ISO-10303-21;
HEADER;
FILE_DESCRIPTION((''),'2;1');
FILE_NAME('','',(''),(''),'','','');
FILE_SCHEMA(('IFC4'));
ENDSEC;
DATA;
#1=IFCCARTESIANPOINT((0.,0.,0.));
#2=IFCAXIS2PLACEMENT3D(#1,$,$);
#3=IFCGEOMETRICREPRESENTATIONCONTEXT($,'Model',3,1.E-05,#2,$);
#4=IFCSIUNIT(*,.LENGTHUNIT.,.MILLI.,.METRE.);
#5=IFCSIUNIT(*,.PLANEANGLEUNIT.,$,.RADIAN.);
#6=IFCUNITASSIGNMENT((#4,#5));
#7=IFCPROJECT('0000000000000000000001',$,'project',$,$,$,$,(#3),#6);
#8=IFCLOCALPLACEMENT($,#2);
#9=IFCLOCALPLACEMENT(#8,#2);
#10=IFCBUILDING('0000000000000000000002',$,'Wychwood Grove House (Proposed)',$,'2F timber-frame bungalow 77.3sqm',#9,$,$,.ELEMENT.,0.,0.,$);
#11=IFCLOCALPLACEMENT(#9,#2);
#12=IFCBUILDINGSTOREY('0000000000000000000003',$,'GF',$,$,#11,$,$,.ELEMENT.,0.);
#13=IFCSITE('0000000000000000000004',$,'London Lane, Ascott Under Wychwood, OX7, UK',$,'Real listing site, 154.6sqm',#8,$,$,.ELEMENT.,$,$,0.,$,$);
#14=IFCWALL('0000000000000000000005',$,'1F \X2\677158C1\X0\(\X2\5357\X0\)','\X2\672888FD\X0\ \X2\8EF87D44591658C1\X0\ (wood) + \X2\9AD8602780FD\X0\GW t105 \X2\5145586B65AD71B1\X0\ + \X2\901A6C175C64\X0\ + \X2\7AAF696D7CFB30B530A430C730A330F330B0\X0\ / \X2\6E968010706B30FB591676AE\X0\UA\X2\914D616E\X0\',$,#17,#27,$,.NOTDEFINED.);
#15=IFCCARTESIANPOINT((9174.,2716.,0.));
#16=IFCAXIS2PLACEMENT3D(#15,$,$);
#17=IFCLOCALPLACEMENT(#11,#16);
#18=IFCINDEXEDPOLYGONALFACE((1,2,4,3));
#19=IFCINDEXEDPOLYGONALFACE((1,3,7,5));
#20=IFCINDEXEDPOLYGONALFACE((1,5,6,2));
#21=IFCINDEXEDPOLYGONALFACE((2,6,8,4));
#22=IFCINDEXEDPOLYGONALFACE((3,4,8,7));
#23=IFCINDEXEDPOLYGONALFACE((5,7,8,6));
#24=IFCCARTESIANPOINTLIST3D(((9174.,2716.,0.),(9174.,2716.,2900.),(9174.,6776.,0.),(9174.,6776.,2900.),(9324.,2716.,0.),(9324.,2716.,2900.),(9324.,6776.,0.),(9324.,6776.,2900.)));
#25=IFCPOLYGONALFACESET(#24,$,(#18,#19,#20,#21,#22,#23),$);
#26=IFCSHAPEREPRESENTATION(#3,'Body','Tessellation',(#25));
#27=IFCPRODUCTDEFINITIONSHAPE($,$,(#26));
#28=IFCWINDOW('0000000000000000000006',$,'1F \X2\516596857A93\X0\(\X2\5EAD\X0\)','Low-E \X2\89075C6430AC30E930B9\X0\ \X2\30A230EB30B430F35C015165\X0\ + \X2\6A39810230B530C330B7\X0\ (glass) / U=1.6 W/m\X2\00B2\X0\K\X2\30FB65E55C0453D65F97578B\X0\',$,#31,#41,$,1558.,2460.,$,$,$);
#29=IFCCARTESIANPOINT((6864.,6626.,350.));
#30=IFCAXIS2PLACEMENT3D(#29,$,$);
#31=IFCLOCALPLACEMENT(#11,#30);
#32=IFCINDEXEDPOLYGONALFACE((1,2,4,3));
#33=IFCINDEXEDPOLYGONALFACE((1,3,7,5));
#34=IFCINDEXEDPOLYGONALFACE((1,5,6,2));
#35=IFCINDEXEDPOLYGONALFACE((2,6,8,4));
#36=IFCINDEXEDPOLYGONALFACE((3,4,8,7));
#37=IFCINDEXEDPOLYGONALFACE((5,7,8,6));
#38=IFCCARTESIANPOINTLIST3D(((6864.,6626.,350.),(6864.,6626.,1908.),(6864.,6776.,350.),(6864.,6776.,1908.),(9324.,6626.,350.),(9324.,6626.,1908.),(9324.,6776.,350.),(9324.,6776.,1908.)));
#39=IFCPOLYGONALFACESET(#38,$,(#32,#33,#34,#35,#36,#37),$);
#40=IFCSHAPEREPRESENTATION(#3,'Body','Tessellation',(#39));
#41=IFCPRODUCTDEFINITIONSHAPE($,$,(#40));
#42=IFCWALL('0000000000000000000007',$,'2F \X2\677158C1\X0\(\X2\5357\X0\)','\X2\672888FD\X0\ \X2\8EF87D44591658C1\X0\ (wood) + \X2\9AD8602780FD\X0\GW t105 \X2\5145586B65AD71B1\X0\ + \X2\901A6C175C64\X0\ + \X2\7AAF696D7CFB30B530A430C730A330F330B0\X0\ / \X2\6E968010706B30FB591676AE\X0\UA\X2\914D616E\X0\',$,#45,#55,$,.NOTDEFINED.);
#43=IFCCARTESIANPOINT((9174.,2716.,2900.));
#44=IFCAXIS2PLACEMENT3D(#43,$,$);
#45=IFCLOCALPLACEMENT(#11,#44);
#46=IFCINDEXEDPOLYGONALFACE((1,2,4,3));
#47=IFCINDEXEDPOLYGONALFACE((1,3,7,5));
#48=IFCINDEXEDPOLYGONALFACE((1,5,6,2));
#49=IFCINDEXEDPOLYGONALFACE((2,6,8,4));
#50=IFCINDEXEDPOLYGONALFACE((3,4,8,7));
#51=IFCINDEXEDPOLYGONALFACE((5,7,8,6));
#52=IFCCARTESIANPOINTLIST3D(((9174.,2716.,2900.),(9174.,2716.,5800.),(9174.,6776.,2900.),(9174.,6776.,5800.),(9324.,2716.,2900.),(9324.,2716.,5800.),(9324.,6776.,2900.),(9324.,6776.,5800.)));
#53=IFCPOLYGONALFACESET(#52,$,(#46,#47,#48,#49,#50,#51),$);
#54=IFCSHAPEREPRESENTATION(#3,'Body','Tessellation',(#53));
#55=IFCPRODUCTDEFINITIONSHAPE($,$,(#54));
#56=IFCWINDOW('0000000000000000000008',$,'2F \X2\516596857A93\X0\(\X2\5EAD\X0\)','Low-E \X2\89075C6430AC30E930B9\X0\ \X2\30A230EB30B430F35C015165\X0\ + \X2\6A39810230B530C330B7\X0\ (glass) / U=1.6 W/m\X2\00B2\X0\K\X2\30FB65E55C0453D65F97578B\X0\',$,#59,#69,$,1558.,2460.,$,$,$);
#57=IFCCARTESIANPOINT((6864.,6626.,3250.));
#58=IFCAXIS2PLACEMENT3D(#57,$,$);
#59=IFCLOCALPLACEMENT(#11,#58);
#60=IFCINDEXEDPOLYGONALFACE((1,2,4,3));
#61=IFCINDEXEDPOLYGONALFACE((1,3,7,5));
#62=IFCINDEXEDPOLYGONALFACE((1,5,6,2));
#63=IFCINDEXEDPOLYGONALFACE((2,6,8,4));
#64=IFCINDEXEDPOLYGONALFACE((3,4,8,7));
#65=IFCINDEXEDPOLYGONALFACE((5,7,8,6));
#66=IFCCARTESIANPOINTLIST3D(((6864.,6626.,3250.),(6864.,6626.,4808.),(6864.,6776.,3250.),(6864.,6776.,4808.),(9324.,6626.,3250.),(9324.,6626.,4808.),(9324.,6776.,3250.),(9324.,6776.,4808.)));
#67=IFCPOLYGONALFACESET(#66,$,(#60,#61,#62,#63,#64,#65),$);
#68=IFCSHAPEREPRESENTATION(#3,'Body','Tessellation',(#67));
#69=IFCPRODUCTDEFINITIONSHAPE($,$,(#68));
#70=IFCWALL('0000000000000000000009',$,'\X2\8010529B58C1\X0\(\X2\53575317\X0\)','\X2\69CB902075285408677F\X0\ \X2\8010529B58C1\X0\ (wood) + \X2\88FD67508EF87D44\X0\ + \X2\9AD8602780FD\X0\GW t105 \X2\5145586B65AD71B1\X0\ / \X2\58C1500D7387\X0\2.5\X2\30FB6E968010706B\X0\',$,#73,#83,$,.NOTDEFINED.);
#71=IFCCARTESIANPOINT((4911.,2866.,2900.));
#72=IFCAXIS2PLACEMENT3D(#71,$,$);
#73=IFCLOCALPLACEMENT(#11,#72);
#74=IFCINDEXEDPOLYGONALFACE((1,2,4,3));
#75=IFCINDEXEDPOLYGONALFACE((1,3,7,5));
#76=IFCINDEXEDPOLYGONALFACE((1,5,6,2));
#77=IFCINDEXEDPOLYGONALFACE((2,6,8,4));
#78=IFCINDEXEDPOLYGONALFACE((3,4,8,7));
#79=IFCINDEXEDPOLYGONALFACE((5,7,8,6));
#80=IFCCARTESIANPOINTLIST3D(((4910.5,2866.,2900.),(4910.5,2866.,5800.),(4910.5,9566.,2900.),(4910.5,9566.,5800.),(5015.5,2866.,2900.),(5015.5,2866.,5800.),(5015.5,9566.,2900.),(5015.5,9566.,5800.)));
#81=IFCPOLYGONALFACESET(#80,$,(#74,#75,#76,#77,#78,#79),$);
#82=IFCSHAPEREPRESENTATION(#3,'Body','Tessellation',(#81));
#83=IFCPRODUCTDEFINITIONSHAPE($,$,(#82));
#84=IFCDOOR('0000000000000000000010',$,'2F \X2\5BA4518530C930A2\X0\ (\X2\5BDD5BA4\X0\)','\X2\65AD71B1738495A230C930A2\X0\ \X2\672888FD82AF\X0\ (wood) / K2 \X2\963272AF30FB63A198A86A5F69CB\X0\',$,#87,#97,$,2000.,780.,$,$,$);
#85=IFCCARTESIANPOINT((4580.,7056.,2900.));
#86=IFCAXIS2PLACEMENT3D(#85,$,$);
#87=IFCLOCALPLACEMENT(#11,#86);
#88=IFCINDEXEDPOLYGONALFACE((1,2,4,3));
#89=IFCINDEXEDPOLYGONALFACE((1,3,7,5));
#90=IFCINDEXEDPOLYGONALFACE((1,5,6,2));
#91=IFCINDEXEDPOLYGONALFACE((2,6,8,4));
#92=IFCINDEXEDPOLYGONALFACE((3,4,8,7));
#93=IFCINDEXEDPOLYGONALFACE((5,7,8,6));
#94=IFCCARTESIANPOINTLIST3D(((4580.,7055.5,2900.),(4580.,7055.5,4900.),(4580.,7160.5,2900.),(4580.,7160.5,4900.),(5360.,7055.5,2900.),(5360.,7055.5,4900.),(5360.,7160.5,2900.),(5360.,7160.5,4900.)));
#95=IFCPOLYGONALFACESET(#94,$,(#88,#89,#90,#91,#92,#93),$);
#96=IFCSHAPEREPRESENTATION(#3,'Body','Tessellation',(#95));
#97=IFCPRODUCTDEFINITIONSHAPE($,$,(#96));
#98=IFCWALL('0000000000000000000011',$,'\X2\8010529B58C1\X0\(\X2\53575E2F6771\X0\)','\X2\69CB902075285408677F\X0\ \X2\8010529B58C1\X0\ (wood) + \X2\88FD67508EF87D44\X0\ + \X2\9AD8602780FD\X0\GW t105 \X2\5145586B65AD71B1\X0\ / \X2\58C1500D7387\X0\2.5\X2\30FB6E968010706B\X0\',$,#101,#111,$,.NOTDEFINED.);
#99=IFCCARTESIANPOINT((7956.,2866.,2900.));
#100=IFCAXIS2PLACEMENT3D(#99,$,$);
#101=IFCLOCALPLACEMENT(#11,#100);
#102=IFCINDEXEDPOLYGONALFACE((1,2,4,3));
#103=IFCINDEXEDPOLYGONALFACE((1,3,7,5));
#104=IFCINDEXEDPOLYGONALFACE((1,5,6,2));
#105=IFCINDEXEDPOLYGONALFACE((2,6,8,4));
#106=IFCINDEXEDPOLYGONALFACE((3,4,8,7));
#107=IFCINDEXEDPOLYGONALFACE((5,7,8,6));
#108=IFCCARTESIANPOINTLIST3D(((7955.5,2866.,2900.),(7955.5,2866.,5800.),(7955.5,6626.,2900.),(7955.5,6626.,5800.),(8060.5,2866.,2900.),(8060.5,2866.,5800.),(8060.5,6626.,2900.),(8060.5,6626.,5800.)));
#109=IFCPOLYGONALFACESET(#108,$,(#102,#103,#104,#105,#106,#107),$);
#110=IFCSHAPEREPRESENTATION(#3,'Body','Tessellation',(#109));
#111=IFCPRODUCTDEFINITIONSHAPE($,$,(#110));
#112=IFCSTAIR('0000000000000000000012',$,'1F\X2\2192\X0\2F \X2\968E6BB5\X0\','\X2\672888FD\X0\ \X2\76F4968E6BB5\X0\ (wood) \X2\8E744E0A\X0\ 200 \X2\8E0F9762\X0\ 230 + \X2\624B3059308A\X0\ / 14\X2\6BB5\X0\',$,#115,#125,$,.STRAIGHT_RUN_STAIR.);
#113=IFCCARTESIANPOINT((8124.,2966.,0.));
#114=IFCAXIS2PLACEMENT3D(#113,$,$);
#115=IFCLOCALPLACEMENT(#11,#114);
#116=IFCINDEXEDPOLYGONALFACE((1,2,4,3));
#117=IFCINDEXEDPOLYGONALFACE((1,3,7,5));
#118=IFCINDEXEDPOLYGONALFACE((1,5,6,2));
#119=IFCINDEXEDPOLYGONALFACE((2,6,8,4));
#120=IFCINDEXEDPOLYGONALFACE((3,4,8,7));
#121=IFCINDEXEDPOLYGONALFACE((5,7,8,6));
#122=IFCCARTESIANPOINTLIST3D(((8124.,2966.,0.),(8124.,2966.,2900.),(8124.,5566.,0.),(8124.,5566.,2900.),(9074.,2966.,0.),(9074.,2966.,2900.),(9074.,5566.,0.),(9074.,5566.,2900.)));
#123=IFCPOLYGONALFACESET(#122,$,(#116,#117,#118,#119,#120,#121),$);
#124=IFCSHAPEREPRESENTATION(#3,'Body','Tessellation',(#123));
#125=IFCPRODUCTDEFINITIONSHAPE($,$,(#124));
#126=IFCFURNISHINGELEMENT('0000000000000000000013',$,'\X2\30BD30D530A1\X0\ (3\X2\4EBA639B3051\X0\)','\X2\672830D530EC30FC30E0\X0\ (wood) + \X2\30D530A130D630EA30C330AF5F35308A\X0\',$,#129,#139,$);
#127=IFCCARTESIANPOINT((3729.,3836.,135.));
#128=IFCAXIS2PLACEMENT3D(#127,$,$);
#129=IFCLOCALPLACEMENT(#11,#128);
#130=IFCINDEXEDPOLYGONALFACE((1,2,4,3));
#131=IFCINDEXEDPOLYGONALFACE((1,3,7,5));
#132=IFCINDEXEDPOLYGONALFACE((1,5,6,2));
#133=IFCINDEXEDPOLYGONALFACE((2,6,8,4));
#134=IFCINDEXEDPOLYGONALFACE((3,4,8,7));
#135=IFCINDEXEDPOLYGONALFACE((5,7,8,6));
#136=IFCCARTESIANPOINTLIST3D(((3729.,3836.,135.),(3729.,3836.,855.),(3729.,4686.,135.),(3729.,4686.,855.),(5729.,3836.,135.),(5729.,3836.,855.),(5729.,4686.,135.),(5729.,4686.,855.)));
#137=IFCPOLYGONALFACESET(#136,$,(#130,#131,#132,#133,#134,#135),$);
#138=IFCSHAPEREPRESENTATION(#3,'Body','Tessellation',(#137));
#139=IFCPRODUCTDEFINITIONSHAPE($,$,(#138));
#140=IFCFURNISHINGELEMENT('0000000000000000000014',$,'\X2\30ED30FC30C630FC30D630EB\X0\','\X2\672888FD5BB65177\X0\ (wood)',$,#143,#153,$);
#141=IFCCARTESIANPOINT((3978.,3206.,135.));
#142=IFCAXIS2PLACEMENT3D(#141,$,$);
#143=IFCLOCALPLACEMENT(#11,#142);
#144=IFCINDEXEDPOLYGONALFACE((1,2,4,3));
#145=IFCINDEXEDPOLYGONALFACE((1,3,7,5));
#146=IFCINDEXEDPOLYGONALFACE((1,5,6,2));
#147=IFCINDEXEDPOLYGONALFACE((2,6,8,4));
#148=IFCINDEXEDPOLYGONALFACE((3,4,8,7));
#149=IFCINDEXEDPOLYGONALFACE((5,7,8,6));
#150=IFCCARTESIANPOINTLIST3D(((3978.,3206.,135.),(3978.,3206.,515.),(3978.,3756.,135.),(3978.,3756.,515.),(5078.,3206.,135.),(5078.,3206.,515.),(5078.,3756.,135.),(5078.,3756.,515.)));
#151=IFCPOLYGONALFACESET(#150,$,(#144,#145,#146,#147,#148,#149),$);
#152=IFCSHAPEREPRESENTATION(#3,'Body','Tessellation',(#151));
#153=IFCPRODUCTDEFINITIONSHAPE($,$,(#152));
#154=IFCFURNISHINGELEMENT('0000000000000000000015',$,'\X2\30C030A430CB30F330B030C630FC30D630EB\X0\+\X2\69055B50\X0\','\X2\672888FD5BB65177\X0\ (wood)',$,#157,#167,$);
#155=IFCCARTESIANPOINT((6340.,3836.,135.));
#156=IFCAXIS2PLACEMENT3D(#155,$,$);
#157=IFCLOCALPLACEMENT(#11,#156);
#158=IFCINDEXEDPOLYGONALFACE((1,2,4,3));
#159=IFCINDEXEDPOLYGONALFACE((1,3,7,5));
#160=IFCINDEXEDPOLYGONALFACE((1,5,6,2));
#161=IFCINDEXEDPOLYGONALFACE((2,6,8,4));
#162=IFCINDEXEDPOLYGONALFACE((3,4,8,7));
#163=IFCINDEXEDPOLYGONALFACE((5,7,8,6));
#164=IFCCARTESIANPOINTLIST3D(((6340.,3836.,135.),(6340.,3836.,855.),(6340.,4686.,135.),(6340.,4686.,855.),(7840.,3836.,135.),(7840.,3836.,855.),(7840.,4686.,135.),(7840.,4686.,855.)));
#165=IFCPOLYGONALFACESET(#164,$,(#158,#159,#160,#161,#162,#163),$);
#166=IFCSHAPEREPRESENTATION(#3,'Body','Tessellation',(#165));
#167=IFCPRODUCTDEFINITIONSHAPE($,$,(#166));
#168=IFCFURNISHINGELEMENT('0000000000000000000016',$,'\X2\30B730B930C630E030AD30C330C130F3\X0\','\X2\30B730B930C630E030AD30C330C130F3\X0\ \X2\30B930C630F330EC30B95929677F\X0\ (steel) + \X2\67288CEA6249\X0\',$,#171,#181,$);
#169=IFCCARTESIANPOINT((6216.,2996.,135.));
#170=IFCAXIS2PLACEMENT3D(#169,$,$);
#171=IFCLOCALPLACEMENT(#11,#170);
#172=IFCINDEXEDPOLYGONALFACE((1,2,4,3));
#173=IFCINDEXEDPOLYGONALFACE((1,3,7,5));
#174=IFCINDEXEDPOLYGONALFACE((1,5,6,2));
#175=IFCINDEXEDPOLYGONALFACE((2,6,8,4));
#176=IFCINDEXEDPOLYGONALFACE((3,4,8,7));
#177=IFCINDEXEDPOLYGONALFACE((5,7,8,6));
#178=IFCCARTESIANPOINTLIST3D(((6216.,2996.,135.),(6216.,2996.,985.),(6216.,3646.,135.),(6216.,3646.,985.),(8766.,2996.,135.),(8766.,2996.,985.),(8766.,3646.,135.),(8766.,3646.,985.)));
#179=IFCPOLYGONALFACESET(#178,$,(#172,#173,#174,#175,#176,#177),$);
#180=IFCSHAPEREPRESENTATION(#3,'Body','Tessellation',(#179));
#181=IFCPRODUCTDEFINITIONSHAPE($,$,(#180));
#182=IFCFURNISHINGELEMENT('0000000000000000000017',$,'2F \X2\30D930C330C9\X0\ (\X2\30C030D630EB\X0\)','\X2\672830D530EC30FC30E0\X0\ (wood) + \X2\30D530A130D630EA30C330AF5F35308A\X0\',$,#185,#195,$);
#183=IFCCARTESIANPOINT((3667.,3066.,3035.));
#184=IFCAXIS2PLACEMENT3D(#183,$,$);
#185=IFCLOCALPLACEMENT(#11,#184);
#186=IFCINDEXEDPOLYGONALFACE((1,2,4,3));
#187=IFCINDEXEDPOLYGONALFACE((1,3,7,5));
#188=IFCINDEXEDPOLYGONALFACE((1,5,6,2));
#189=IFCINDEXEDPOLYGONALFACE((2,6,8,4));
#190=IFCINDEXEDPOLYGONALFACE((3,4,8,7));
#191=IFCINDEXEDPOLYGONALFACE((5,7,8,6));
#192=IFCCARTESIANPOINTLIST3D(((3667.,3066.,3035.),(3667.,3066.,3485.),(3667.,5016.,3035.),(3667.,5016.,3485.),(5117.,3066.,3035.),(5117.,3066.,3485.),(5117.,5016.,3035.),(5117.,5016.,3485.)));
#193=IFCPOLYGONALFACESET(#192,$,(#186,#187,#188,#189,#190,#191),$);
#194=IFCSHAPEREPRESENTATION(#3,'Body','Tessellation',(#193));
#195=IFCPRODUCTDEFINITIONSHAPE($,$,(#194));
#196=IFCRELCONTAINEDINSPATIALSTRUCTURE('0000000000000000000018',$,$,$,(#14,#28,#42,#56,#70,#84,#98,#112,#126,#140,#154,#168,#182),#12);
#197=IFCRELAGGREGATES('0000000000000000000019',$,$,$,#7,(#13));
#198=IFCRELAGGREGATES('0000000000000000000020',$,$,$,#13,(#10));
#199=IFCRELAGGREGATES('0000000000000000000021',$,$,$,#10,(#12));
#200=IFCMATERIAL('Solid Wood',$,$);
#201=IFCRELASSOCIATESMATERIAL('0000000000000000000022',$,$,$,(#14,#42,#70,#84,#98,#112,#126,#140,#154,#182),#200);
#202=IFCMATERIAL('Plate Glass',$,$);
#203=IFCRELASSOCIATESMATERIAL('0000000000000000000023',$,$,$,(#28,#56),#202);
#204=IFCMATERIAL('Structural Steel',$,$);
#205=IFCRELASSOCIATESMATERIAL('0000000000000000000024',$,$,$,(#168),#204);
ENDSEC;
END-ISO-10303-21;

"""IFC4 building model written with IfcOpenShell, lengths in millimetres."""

from ifc_helpers import new_model, si_unit, frame, frame_2d, origin, place, context, project, spatial, rectangle, extrude, material, element, fill, save


model = new_model("IFC4")

# Units and contexts
model_context = context("Model", 3, precision=1e-05, world=origin())
ifc_project = project(units=[si_unit("LENGTHUNIT", "METRE", prefix="MILLI"), si_unit("PLANEANGLEUNIT", "RADIAN")], contexts=[model_context])

# Site, building, storey
site_placement = place(None, origin())
site = spatial("IfcSite", under=ifc_project, at=site_placement, Name="London Lane, Ascott Under Wychwood, OX7, UK", ObjectType="Real listing site, 154.6sqm", CompositionType="ELEMENT", RefElevation=0.0)
building_placement = place(site_placement, origin())
building = spatial("IfcBuilding", under=site, at=building_placement, Name="Wychwood Grove House (Proposed)", ObjectType="2F timber-frame bungalow 77.3sqm", CompositionType="ELEMENT", ElevationOfRefHeight=0.0, ElevationOfTerrain=0.0)
storey_placement = place(building_placement, origin())
storey = spatial("IfcBuildingStorey", under=building, at=storey_placement, Name="GF", CompositionType="ELEMENT", Elevation=0.0)

# Wall, opening, window
ifc_material_1 = material(Name="Solid Wood")
wall_1_placement = place(storey_placement, frame((9174.0, 2716.0, 0.0)))
wall_1 = element("IfcWall", 1, at=wall_1_placement, inside=storey, material=ifc_material_1, Name="1F 東壁(南)", Description="木製 軸組外壁 (wood) + 高性能GW t105 充填断熱 + 通気層 + 窯業系サイディング / 準耐火・外皮UA配慮", PredefinedType="NOTDEFINED", context=model_context, shape_type="SweptSolid", body=[
    extrude(rectangle(XDim=150.0, YDim=4060.0, at=frame_2d((75.0, 2030.0))), frame((9174.0, 2716.0, 0.0)), (0.0, 0.0, 1.0), 2900.0),
])
opening_1_placement = place(storey_placement, frame((6864.0, 6626.0, 350.0)))
opening_1 = element("IfcOpeningElement", 2, at=opening_1_placement, cuts=wall_1, PredefinedType="NOTDEFINED", context=model_context, shape_type="SweptSolid", body=[
    extrude(rectangle(XDim=2460.0, YDim=150.0, at=frame_2d((1230.0, 75.0))), frame((6864.0, 6626.0, 350.0)), (0.0, 0.0, 1.0), 1558.0),
])
ifc_material_2 = material(Name="Plate Glass")
window_1_placement = place(storey_placement, frame((6864.0, 6626.0, 350.0)))
window_1 = element("IfcWindow", 3, at=window_1_placement, inside=storey, material=ifc_material_2, Name="1F 入隅窓(庭)", Description="Low-E 複層ガラス アルゴン封入 + 樹脂サッシ (glass) / U=1.6 W/m²K・日射取得型", OverallHeight=1558.0, OverallWidth=2460.0, context=model_context, shape_type="SweptSolid", body=[
    extrude(rectangle(XDim=2460.0, YDim=150.0, at=frame_2d((1230.0, 75.0))), frame((6864.0, 6626.0, 350.0)), (0.0, 0.0, 1.0), 1558.0),
])
fill(opening_1, window_1)

# Wall, opening, window
wall_2_placement = place(storey_placement, frame((9174.0, 2716.0, 2900.0)))
wall_2 = element("IfcWall", 4, at=wall_2_placement, inside=storey, material=ifc_material_1, Name="2F 東壁(南)", Description="木製 軸組外壁 (wood) + 高性能GW t105 充填断熱 + 通気層 + 窯業系サイディング / 準耐火・外皮UA配慮", PredefinedType="NOTDEFINED", context=model_context, shape_type="SweptSolid", body=[
    extrude(rectangle(XDim=150.0, YDim=4060.0, at=frame_2d((75.0, 2030.0))), frame((9174.0, 2716.0, 2900.0)), (0.0, 0.0, 1.0), 2900.0),
])
opening_2_placement = place(storey_placement, frame((6864.0, 6626.0, 3250.0)))
opening_2 = element("IfcOpeningElement", 5, at=opening_2_placement, cuts=wall_2, PredefinedType="NOTDEFINED", context=model_context, shape_type="SweptSolid", body=[
    extrude(rectangle(XDim=2460.0, YDim=150.0, at=frame_2d((1230.0, 75.0))), frame((6864.0, 6626.0, 3250.0)), (0.0, 0.0, 1.0), 1558.0),
])
window_2_placement = place(storey_placement, frame((6864.0, 6626.0, 3250.0)))
window_2 = element("IfcWindow", 6, at=window_2_placement, inside=storey, material=ifc_material_2, Name="2F 入隅窓(庭)", Description="Low-E 複層ガラス アルゴン封入 + 樹脂サッシ (glass) / U=1.6 W/m²K・日射取得型", OverallHeight=1558.0, OverallWidth=2460.0, context=model_context, shape_type="SweptSolid", body=[
    extrude(rectangle(XDim=2460.0, YDim=150.0, at=frame_2d((1230.0, 75.0))), frame((6864.0, 6626.0, 3250.0)), (0.0, 0.0, 1.0), 1558.0),
])
fill(opening_2, window_2)

# Wall, opening, door
wall_3_placement = place(storey_placement, frame((4911.0, 2866.0, 2900.0)))
wall_3 = element("IfcWall", 7, at=wall_3_placement, inside=storey, material=ifc_material_1, Name="耐力壁(南北)", Description="構造用合板 耐力壁 (wood) + 製材軸組 + 高性能GW t105 充填断熱 / 壁倍率2.5・準耐火", PredefinedType="NOTDEFINED", context=model_context, shape_type="SweptSolid", body=[
    extrude(rectangle(XDim=105.0, YDim=6700.0, at=frame_2d((52.0, 3350.0))), frame((4911.0, 2866.0, 2900.0)), (0.0, 0.0, 1.0), 2900.0),
])
opening_3_placement = place(storey_placement, frame((4580.0, 7056.0, 2900.0)))
opening_3 = element("IfcOpeningElement", 8, at=opening_3_placement, cuts=wall_3, PredefinedType="NOTDEFINED", context=model_context, shape_type="SweptSolid", body=[
    extrude(rectangle(XDim=780.0, YDim=105.0, at=frame_2d((390.0, 52.0))), frame((4580.0, 7056.0, 2900.0)), (0.0, 0.0, 1.0), 2000.0),
])
door_1_placement = place(storey_placement, frame((4580.0, 7056.0, 2900.0)))
door_1 = element("IfcDoor", 9, at=door_1_placement, inside=storey, material=ifc_material_1, Name="2F 室内ドア (寝室)", Description="断熱玄関ドア 木製芯 (wood) / K2 防犯・採風機構", OverallHeight=2000.0, OverallWidth=780.0, context=model_context, shape_type="SweptSolid", body=[
    extrude(rectangle(XDim=780.0, YDim=105.0, at=frame_2d((390.0, 52.0))), frame((4580.0, 7056.0, 2900.0)), (0.0, 0.0, 1.0), 2000.0),
])
fill(opening_3, door_1)

# Wall
wall_4_placement = place(storey_placement, frame((7956.0, 2866.0, 2900.0)))
element("IfcWall", 10, at=wall_4_placement, inside=storey, material=ifc_material_1, Name="耐力壁(南帯東)", Description="構造用合板 耐力壁 (wood) + 製材軸組 + 高性能GW t105 充填断熱 / 壁倍率2.5・準耐火", PredefinedType="NOTDEFINED", context=model_context, shape_type="SweptSolid", body=[
    extrude(rectangle(XDim=105.0, YDim=3760.0, at=frame_2d((52.0, 1880.0))), frame((7956.0, 2866.0, 2900.0)), (0.0, 0.0, 1.0), 2900.0),
])

# Stair
stair_placement = place(storey_placement, frame((8124.0, 2966.0, 0.0)))
element("IfcStair", 11, at=stair_placement, inside=storey, material=ifc_material_1, Name="1F→2F 階段", Description="木製 直階段 (wood) 蹴上 200 踏面 230 + 手すり / 14段", PredefinedType="STRAIGHT_RUN_STAIR", context=model_context, shape_type="SweptSolid", body=[
    extrude(rectangle(XDim=950.0, YDim=2600.0, at=frame_2d((475.0, 1300.0))), frame((8124.0, 2966.0, 0.0)), (0.0, 0.0, 1.0), 2900.0),
])

# Furnishing elements
furnishing_1_placement = place(storey_placement, frame((3729.0, 3836.0, 135.0)))
element("IfcFurnishingElement", 12, at=furnishing_1_placement, inside=storey, material=ifc_material_1, Name="ソファ (3人掛け)", Description="木フレーム (wood) + ファブリック張り", context=model_context, shape_type="SweptSolid", body=[
    extrude(rectangle(XDim=2000.0, YDim=850.0, at=frame_2d((1000.0, 425.0))), frame((3729.0, 3836.0, 135.0)), (0.0, 0.0, 1.0), 720.0),
])
furnishing_2_placement = place(storey_placement, frame((3978.0, 3206.0, 135.0)))
element("IfcFurnishingElement", 13, at=furnishing_2_placement, inside=storey, material=ifc_material_1, Name="ローテーブル", Description="木製家具 (wood)", context=model_context, shape_type="SweptSolid", body=[
    extrude(rectangle(XDim=1100.0, YDim=550.0, at=frame_2d((550.0, 275.0))), frame((3978.0, 3206.0, 135.0)), (0.0, 0.0, 1.0), 380.0),
])
furnishing_3_placement = place(storey_placement, frame((6340.0, 3836.0, 135.0)))
element("IfcFurnishingElement", 14, at=furnishing_3_placement, inside=storey, material=ifc_material_1, Name="ダイニングテーブル+椅子", Description="木製家具 (wood)", context=model_context, shape_type="SweptSolid", body=[
    extrude(rectangle(XDim=1500.0, YDim=850.0, at=frame_2d((750.0, 425.0))), frame((6340.0, 3836.0, 135.0)), (0.0, 0.0, 1.0), 720.0),
])
ifc_material_3 = material(Name="Structural Steel")
furnishing_4_placement = place(storey_placement, frame((6216.0, 2996.0, 135.0)))
element("IfcFurnishingElement", 15, at=furnishing_4_placement, inside=storey, material=ifc_material_3, Name="システムキッチン", Description="システムキッチン ステンレス天板 (steel) + 木質扉", context=model_context, shape_type="SweptSolid", body=[
    extrude(rectangle(XDim=2550.0, YDim=650.0, at=frame_2d((1275.0, 325.0))), frame((6216.0, 2996.0, 135.0)), (0.0, 0.0, 1.0), 850.0),
])
furnishing_5_placement = place(storey_placement, frame((3667.0, 3066.0, 3035.0)))
element("IfcFurnishingElement", 16, at=furnishing_5_placement, inside=storey, material=ifc_material_1, Name="2F ベッド (ダブル)", Description="木フレーム (wood) + ファブリック張り", context=model_context, shape_type="SweptSolid", body=[
    extrude(rectangle(XDim=1450.0, YDim=1950.0, at=frame_2d((725.0, 975.0))), frame((3667.0, 3066.0, 3035.0)), (0.0, 0.0, 1.0), 450.0),
])

save(model, "model.ifc")
